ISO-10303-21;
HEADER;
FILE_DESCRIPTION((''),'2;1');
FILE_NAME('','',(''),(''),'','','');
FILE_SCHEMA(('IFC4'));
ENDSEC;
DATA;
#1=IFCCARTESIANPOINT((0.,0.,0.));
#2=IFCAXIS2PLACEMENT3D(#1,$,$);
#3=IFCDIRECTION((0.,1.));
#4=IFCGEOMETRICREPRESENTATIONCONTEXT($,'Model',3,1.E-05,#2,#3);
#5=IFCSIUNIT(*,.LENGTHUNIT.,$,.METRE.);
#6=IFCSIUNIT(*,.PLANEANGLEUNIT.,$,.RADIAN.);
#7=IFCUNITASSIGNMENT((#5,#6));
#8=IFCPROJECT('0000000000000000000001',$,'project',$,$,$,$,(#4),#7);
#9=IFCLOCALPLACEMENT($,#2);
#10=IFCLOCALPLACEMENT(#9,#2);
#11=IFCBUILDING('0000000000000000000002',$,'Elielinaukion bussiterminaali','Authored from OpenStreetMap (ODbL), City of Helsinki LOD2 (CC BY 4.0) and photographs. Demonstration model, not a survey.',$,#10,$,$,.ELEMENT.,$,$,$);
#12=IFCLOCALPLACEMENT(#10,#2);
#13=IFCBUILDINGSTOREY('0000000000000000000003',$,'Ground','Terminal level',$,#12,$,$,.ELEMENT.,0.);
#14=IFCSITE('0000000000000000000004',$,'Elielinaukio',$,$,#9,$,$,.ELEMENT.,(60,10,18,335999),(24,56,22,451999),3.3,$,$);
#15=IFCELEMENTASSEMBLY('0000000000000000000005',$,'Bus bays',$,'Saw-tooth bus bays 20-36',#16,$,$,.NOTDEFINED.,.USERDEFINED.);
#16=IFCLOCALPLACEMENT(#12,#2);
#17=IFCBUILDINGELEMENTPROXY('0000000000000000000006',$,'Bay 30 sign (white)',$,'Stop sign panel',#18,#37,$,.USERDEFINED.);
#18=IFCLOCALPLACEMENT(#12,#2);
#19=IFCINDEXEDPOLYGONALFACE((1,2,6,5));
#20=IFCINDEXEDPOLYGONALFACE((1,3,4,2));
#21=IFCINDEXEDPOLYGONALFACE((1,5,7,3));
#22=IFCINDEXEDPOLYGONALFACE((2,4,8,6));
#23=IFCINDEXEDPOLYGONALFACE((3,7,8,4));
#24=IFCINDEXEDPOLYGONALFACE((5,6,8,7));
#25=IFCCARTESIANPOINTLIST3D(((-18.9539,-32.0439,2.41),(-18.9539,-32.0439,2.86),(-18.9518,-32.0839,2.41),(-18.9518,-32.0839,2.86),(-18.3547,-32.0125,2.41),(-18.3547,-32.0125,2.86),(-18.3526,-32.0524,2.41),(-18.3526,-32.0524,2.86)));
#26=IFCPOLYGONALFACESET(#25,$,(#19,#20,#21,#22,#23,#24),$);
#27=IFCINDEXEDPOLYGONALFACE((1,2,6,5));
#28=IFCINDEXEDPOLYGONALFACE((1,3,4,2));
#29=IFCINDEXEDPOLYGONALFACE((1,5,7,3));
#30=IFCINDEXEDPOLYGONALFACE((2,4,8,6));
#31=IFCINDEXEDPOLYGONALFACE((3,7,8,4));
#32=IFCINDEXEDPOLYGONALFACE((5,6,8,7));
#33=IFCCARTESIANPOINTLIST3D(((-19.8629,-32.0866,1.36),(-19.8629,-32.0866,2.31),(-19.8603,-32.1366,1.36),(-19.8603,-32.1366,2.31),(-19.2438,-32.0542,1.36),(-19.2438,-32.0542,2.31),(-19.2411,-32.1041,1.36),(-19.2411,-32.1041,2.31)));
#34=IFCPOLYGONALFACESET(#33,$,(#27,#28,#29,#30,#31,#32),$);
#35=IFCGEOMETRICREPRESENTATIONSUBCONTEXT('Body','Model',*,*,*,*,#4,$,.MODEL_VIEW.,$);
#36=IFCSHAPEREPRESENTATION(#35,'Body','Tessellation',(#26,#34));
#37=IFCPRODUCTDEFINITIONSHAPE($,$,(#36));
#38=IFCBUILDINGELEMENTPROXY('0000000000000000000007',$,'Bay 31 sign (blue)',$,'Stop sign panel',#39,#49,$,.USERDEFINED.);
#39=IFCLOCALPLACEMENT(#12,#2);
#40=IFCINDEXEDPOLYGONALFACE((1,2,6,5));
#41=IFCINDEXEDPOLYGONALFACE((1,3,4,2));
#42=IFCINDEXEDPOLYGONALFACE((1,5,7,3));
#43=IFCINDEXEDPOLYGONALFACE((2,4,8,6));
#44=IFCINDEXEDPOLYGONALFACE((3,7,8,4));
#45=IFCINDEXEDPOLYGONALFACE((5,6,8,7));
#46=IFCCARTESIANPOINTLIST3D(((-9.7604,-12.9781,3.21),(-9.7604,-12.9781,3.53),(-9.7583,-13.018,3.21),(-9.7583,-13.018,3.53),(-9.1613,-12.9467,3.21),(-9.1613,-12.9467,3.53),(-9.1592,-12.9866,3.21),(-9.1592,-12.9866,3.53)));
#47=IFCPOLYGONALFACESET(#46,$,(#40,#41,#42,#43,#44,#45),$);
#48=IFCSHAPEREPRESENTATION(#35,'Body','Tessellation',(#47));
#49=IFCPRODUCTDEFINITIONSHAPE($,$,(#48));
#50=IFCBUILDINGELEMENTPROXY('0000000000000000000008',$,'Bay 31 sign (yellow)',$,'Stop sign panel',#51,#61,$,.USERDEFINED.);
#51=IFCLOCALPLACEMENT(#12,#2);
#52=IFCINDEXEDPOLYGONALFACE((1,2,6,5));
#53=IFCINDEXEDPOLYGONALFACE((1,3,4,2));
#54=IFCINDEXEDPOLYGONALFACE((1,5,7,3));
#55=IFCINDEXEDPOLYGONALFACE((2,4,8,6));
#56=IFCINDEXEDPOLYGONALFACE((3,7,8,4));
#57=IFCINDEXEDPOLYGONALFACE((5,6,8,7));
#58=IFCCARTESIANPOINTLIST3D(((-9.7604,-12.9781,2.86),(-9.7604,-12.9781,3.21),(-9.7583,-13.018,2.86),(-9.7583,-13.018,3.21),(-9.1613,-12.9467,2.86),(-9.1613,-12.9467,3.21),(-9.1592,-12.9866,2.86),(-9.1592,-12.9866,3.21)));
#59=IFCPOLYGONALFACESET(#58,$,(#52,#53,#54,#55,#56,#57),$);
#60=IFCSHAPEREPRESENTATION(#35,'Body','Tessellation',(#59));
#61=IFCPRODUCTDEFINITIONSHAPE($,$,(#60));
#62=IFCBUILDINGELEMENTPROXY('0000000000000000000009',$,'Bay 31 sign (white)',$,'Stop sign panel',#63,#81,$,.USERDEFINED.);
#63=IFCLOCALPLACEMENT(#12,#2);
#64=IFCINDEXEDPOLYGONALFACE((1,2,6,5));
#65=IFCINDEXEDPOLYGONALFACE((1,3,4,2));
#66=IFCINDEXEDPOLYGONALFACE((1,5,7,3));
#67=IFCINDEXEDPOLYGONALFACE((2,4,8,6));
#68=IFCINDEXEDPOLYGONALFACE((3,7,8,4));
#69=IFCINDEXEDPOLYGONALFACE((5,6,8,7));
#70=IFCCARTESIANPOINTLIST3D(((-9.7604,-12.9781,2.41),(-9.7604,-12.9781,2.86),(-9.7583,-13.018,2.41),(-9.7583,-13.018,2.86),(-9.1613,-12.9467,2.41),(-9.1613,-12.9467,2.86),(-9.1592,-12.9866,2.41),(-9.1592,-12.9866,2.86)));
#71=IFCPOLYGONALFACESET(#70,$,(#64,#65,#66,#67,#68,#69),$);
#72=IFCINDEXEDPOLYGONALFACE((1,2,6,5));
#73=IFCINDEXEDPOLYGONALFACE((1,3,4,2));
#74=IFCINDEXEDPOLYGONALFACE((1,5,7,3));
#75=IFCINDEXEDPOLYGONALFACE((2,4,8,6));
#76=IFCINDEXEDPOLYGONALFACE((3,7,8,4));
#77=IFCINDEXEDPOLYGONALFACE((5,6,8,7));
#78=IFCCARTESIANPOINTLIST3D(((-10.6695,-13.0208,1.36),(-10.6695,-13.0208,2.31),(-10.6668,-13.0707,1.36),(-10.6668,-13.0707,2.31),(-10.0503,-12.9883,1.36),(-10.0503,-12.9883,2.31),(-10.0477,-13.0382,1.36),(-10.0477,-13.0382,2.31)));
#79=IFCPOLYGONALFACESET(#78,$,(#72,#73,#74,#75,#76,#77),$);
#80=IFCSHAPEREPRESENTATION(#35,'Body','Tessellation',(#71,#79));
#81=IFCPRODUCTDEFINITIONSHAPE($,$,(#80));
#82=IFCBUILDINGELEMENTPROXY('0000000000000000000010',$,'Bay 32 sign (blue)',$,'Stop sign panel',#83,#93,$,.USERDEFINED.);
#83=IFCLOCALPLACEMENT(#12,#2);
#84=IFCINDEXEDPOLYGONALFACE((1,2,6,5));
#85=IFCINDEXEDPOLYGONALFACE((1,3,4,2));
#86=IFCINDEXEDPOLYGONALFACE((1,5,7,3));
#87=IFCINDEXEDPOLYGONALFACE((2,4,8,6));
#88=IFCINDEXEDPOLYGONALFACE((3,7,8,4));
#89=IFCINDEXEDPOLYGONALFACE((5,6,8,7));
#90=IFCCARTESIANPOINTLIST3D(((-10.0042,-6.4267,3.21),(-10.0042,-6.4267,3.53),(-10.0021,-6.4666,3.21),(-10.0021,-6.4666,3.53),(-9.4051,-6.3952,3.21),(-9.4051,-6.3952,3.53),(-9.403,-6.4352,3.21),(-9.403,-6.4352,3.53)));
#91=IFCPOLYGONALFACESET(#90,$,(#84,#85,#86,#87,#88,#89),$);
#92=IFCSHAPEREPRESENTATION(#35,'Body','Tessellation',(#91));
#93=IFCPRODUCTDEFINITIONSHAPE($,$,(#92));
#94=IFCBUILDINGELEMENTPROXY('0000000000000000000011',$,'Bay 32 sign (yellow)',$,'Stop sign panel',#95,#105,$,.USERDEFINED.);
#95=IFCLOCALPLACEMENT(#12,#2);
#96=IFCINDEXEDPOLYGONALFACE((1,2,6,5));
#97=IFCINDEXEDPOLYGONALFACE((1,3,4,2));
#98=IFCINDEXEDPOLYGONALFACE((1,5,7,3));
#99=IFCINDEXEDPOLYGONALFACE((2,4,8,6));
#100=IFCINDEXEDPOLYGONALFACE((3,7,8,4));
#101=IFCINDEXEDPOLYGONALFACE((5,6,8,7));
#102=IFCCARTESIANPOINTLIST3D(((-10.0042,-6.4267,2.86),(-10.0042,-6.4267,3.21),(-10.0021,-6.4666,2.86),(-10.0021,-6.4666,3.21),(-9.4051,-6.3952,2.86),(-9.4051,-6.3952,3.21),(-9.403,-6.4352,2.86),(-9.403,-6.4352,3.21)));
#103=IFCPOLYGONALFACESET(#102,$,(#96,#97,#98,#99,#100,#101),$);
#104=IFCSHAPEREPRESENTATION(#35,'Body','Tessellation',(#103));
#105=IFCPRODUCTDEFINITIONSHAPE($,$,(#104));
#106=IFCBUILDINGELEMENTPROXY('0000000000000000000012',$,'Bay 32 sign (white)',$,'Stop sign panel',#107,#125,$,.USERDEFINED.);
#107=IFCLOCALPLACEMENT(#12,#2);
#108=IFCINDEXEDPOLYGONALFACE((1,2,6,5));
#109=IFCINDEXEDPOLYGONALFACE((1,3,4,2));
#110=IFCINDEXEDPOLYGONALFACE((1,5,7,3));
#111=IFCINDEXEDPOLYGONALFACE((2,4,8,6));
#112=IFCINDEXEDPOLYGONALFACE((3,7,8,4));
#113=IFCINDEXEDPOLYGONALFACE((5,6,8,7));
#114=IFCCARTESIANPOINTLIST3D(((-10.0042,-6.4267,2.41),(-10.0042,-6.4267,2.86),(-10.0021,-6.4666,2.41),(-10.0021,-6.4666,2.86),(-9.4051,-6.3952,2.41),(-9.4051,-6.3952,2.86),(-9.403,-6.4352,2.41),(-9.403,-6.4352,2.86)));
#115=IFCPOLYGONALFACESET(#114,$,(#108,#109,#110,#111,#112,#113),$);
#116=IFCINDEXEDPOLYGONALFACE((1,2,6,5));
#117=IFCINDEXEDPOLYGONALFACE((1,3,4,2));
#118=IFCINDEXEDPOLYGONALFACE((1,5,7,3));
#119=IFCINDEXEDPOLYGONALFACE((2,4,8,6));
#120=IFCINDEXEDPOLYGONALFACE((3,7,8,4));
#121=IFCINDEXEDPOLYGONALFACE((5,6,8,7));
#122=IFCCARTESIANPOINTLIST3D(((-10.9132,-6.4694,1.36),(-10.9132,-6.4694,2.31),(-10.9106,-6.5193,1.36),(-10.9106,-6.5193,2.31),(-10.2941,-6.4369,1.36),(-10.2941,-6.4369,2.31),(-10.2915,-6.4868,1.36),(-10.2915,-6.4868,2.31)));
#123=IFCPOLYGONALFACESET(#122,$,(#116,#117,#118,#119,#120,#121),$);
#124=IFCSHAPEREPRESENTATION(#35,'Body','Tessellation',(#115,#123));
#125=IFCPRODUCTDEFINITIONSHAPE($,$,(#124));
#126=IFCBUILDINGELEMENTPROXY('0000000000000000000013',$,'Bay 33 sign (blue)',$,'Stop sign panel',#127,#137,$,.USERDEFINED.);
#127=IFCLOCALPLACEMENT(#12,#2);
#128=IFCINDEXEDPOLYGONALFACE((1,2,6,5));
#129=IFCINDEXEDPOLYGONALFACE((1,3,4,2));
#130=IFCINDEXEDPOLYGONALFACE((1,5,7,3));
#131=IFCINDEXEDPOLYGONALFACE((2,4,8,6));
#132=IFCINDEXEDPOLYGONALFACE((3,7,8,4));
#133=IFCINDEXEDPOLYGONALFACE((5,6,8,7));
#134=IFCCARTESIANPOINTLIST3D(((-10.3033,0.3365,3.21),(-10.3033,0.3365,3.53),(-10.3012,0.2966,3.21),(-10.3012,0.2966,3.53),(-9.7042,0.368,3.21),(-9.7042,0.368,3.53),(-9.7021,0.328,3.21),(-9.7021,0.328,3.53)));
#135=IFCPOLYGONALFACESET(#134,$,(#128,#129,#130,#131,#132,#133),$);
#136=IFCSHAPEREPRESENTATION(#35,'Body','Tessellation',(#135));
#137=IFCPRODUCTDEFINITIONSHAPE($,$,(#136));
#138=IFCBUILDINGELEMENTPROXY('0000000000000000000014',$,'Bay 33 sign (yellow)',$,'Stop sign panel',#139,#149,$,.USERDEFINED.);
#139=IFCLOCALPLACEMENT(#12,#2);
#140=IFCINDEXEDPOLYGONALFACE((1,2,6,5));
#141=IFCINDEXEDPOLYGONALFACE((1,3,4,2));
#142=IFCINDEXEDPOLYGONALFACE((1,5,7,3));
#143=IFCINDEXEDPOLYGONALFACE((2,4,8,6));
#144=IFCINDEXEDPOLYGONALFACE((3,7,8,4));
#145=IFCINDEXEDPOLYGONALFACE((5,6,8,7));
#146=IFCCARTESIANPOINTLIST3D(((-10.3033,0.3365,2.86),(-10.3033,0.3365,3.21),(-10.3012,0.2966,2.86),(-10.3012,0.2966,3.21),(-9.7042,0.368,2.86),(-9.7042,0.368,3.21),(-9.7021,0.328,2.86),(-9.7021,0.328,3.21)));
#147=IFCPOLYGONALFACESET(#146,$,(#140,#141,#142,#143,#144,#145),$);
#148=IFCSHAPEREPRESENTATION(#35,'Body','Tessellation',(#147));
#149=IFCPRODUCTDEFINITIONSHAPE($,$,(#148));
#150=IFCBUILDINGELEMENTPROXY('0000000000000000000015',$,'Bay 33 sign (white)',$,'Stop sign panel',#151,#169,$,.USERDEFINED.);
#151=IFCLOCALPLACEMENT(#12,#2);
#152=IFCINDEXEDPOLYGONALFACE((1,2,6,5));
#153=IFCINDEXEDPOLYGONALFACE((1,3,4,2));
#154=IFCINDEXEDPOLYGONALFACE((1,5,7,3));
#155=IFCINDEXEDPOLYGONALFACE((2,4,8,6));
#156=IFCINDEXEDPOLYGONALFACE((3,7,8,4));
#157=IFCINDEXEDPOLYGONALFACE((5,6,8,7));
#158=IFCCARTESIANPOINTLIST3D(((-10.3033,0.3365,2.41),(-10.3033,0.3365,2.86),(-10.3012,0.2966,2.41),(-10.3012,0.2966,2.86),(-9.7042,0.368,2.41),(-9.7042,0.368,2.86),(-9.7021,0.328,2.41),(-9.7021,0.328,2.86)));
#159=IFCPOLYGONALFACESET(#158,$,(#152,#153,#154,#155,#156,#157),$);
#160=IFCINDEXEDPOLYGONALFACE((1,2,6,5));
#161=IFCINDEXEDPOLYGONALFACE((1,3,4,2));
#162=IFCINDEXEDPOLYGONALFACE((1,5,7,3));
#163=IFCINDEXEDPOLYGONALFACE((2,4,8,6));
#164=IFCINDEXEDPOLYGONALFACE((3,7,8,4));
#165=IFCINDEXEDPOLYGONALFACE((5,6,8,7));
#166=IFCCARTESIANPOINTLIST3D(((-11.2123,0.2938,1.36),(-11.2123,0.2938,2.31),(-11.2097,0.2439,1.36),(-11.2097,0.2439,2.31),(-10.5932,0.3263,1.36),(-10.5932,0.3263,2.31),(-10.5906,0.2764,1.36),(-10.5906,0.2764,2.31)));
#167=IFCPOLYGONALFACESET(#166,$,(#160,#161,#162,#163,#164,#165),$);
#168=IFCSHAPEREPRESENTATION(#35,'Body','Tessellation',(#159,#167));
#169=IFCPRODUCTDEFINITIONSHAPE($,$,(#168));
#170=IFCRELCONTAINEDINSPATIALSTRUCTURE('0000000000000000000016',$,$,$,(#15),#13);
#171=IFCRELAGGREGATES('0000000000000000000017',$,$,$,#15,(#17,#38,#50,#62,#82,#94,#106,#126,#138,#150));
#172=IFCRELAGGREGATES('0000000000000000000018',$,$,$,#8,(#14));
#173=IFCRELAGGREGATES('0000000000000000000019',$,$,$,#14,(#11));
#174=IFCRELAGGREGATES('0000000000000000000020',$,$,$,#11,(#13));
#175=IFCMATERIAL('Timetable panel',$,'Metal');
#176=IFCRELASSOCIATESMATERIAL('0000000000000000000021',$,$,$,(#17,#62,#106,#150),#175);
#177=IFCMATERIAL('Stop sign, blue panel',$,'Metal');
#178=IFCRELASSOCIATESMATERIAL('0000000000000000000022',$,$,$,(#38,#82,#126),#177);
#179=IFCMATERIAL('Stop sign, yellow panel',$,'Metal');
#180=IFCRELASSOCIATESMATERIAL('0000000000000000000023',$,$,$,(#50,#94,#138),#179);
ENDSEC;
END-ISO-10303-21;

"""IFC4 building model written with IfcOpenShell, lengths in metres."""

from ifc_helpers import new_model, si_unit, direction, frame, frame_2d, origin, place, context, subcontext, project, spatial, rectangle, extrude, material, element, aggregate, save


model = new_model("IFC4")

# Units and contexts
model_context = context("Model", 3, precision=1e-05, world=origin(), true_north=direction((0.0, 1.0)))
body_context = subcontext(model_context, "Body", "Model", "MODEL_VIEW")
ifc_project = project(units=[si_unit("LENGTHUNIT", "METRE"), si_unit("PLANEANGLEUNIT", "RADIAN")], contexts=[model_context])

# Site, building, storey
site_placement = place(None, origin())
site = spatial("IfcSite", under=ifc_project, at=site_placement, Name="Elielinaukio", CompositionType="ELEMENT", RefLatitude=(60, 10, 18, 335999), RefLongitude=(24, 56, 22, 451999), RefElevation=3.3)
building_placement = place(site_placement, origin())
building = spatial("IfcBuilding", under=site, at=building_placement, Name="Elielinaukion bussiterminaali", Description="Authored from OpenStreetMap (ODbL), City of Helsinki LOD2 (CC BY 4.0) and photographs. Demonstration model, not a survey.", CompositionType="ELEMENT")
storey_placement = place(building_placement, origin())
storey = spatial("IfcBuildingStorey", under=building, at=storey_placement, Name="Ground", Description="Terminal level", CompositionType="ELEMENT", Elevation=0.0)

# Element assembly, building element proxies
assembly_placement = place(building_placement, origin())
assembly = element("IfcElementAssembly", 1, at=assembly_placement, inside=storey, Name="Bus bays", ObjectType="Saw-tooth bus bays 20-36", AssemblyPlace="NOTDEFINED", PredefinedType="USERDEFINED")
ifc_material_1 = material(Name="Stop sign, blue panel", Category="Metal")
ifc_material_2 = material(Name="Stop sign, yellow panel", Category="Metal")
ifc_material_3 = material(Name="Timetable panel", Category="Metal")
proxy_1_placement = place(building_placement, origin())
proxy_1 = element("IfcBuildingElementProxy", 2, at=proxy_1_placement, material=ifc_material_3, Name="Bay 30 sign (white)", ObjectType="Stop sign panel", PredefinedType="USERDEFINED", context=body_context, shape_type="SweptSolid", body=[
    extrude(rectangle(XDim=0.04, YDim=0.6, at=frame_2d((0.0, 0.0), x_axis=(-0.052408, 0.998626))), frame((-18.6533, -32.0482, 2.41)), (0.0, 0.0, 1.0), 0.45),
    extrude(rectangle(XDim=0.05, YDim=0.62, at=frame_2d((0.0, 0.0), x_axis=(-0.052408, 0.998626))), frame((-19.552, -32.0954, 1.36)), (0.0, 0.0, 1.0), 0.95),
])
proxy_2_placement = place(building_placement, origin())
proxy_2 = element("IfcBuildingElementProxy", 3, at=proxy_2_placement, material=ifc_material_1, Name="Bay 31 sign (blue)", ObjectType="Stop sign panel", PredefinedType="USERDEFINED", context=body_context, shape_type="SweptSolid", body=[
    extrude(rectangle(XDim=0.04, YDim=0.6, at=frame_2d((0.0, 0.0), x_axis=(-0.052408, 0.998626))), frame((-9.4598, -12.9824, 3.21)), (0.0, 0.0, 1.0), 0.32),
])
proxy_3_placement = place(building_placement, origin())
proxy_3 = element("IfcBuildingElementProxy", 4, at=proxy_3_placement, material=ifc_material_2, Name="Bay 31 sign (yellow)", ObjectType="Stop sign panel", PredefinedType="USERDEFINED", context=body_context, shape_type="SweptSolid", body=[
    extrude(rectangle(XDim=0.04, YDim=0.6, at=frame_2d((0.0, 0.0), x_axis=(-0.052408, 0.998626))), frame((-9.4598, -12.9824, 2.86)), (0.0, 0.0, 1.0), 0.35),
])
proxy_4_placement = place(building_placement, origin())
proxy_4 = element("IfcBuildingElementProxy", 5, at=proxy_4_placement, material=ifc_material_3, Name="Bay 31 sign (white)", ObjectType="Stop sign panel", PredefinedType="USERDEFINED", context=body_context, shape_type="SweptSolid", body=[
    extrude(rectangle(XDim=0.04, YDim=0.6, at=frame_2d((0.0, 0.0), x_axis=(-0.052408, 0.998626))), frame((-9.4598, -12.9824, 2.41)), (0.0, 0.0, 1.0), 0.45),
    extrude(rectangle(XDim=0.05, YDim=0.62, at=frame_2d((0.0, 0.0), x_axis=(-0.052408, 0.998626))), frame((-10.3586, -13.0295, 1.36)), (0.0, 0.0, 1.0), 0.95),
])
proxy_5_placement = place(building_placement, origin())
proxy_5 = element("IfcBuildingElementProxy", 6, at=proxy_5_placement, material=ifc_material_1, Name="Bay 32 sign (blue)", ObjectType="Stop sign panel", PredefinedType="USERDEFINED", context=body_context, shape_type="SweptSolid", body=[
    extrude(rectangle(XDim=0.04, YDim=0.6, at=frame_2d((0.0, 0.0), x_axis=(-0.052408, 0.998626))), frame((-9.7036, -6.4309, 3.21)), (0.0, 0.0, 1.0), 0.32),
])
proxy_6_placement = place(building_placement, origin())
proxy_6 = element("IfcBuildingElementProxy", 7, at=proxy_6_placement, material=ifc_material_2, Name="Bay 32 sign (yellow)", ObjectType="Stop sign panel", PredefinedType="USERDEFINED", context=body_context, shape_type="SweptSolid", body=[
    extrude(rectangle(XDim=0.04, YDim=0.6, at=frame_2d((0.0, 0.0), x_axis=(-0.052408, 0.998626))), frame((-9.7036, -6.4309, 2.86)), (0.0, 0.0, 1.0), 0.35),
])
proxy_7_placement = place(building_placement, origin())
proxy_7 = element("IfcBuildingElementProxy", 8, at=proxy_7_placement, material=ifc_material_3, Name="Bay 32 sign (white)", ObjectType="Stop sign panel", PredefinedType="USERDEFINED", context=body_context, shape_type="SweptSolid", body=[
    extrude(rectangle(XDim=0.04, YDim=0.6, at=frame_2d((0.0, 0.0), x_axis=(-0.052408, 0.998626))), frame((-9.7036, -6.4309, 2.41)), (0.0, 0.0, 1.0), 0.45),
    extrude(rectangle(XDim=0.05, YDim=0.62, at=frame_2d((0.0, 0.0), x_axis=(-0.052408, 0.998626))), frame((-10.6024, -6.4781, 1.36)), (0.0, 0.0, 1.0), 0.95),
])
proxy_8_placement = place(building_placement, origin())
proxy_8 = element("IfcBuildingElementProxy", 9, at=proxy_8_placement, material=ifc_material_1, Name="Bay 33 sign (blue)", ObjectType="Stop sign panel", PredefinedType="USERDEFINED", context=body_context, shape_type="SweptSolid", body=[
    extrude(rectangle(XDim=0.04, YDim=0.6, at=frame_2d((0.0, 0.0), x_axis=(-0.052408, 0.998626))), frame((-10.0027, 0.3323, 3.21)), (0.0, 0.0, 1.0), 0.32),
])
proxy_9_placement = place(building_placement, origin())
proxy_9 = element("IfcBuildingElementProxy", 10, at=proxy_9_placement, material=ifc_material_2, Name="Bay 33 sign (yellow)", ObjectType="Stop sign panel", PredefinedType="USERDEFINED", context=body_context, shape_type="SweptSolid", body=[
    extrude(rectangle(XDim=0.04, YDim=0.6, at=frame_2d((0.0, 0.0), x_axis=(-0.052408, 0.998626))), frame((-10.0027, 0.3323, 2.86)), (0.0, 0.0, 1.0), 0.35),
])
proxy_10_placement = place(building_placement, origin())
proxy_10 = element("IfcBuildingElementProxy", 11, at=proxy_10_placement, material=ifc_material_3, Name="Bay 33 sign (white)", ObjectType="Stop sign panel", PredefinedType="USERDEFINED", context=body_context, shape_type="SweptSolid", body=[
    extrude(rectangle(XDim=0.04, YDim=0.6, at=frame_2d((0.0, 0.0), x_axis=(-0.052408, 0.998626))), frame((-10.0027, 0.3323, 2.41)), (0.0, 0.0, 1.0), 0.45),
    extrude(rectangle(XDim=0.05, YDim=0.62, at=frame_2d((0.0, 0.0), x_axis=(-0.052408, 0.998626))), frame((-10.9015, 0.2851, 1.36)), (0.0, 0.0, 1.0), 0.95),
])
aggregate(assembly, [proxy_1, proxy_2, proxy_3, proxy_4, proxy_5, proxy_6, proxy_7, proxy_8, proxy_9, proxy_10])

save(model, "model.ifc")
